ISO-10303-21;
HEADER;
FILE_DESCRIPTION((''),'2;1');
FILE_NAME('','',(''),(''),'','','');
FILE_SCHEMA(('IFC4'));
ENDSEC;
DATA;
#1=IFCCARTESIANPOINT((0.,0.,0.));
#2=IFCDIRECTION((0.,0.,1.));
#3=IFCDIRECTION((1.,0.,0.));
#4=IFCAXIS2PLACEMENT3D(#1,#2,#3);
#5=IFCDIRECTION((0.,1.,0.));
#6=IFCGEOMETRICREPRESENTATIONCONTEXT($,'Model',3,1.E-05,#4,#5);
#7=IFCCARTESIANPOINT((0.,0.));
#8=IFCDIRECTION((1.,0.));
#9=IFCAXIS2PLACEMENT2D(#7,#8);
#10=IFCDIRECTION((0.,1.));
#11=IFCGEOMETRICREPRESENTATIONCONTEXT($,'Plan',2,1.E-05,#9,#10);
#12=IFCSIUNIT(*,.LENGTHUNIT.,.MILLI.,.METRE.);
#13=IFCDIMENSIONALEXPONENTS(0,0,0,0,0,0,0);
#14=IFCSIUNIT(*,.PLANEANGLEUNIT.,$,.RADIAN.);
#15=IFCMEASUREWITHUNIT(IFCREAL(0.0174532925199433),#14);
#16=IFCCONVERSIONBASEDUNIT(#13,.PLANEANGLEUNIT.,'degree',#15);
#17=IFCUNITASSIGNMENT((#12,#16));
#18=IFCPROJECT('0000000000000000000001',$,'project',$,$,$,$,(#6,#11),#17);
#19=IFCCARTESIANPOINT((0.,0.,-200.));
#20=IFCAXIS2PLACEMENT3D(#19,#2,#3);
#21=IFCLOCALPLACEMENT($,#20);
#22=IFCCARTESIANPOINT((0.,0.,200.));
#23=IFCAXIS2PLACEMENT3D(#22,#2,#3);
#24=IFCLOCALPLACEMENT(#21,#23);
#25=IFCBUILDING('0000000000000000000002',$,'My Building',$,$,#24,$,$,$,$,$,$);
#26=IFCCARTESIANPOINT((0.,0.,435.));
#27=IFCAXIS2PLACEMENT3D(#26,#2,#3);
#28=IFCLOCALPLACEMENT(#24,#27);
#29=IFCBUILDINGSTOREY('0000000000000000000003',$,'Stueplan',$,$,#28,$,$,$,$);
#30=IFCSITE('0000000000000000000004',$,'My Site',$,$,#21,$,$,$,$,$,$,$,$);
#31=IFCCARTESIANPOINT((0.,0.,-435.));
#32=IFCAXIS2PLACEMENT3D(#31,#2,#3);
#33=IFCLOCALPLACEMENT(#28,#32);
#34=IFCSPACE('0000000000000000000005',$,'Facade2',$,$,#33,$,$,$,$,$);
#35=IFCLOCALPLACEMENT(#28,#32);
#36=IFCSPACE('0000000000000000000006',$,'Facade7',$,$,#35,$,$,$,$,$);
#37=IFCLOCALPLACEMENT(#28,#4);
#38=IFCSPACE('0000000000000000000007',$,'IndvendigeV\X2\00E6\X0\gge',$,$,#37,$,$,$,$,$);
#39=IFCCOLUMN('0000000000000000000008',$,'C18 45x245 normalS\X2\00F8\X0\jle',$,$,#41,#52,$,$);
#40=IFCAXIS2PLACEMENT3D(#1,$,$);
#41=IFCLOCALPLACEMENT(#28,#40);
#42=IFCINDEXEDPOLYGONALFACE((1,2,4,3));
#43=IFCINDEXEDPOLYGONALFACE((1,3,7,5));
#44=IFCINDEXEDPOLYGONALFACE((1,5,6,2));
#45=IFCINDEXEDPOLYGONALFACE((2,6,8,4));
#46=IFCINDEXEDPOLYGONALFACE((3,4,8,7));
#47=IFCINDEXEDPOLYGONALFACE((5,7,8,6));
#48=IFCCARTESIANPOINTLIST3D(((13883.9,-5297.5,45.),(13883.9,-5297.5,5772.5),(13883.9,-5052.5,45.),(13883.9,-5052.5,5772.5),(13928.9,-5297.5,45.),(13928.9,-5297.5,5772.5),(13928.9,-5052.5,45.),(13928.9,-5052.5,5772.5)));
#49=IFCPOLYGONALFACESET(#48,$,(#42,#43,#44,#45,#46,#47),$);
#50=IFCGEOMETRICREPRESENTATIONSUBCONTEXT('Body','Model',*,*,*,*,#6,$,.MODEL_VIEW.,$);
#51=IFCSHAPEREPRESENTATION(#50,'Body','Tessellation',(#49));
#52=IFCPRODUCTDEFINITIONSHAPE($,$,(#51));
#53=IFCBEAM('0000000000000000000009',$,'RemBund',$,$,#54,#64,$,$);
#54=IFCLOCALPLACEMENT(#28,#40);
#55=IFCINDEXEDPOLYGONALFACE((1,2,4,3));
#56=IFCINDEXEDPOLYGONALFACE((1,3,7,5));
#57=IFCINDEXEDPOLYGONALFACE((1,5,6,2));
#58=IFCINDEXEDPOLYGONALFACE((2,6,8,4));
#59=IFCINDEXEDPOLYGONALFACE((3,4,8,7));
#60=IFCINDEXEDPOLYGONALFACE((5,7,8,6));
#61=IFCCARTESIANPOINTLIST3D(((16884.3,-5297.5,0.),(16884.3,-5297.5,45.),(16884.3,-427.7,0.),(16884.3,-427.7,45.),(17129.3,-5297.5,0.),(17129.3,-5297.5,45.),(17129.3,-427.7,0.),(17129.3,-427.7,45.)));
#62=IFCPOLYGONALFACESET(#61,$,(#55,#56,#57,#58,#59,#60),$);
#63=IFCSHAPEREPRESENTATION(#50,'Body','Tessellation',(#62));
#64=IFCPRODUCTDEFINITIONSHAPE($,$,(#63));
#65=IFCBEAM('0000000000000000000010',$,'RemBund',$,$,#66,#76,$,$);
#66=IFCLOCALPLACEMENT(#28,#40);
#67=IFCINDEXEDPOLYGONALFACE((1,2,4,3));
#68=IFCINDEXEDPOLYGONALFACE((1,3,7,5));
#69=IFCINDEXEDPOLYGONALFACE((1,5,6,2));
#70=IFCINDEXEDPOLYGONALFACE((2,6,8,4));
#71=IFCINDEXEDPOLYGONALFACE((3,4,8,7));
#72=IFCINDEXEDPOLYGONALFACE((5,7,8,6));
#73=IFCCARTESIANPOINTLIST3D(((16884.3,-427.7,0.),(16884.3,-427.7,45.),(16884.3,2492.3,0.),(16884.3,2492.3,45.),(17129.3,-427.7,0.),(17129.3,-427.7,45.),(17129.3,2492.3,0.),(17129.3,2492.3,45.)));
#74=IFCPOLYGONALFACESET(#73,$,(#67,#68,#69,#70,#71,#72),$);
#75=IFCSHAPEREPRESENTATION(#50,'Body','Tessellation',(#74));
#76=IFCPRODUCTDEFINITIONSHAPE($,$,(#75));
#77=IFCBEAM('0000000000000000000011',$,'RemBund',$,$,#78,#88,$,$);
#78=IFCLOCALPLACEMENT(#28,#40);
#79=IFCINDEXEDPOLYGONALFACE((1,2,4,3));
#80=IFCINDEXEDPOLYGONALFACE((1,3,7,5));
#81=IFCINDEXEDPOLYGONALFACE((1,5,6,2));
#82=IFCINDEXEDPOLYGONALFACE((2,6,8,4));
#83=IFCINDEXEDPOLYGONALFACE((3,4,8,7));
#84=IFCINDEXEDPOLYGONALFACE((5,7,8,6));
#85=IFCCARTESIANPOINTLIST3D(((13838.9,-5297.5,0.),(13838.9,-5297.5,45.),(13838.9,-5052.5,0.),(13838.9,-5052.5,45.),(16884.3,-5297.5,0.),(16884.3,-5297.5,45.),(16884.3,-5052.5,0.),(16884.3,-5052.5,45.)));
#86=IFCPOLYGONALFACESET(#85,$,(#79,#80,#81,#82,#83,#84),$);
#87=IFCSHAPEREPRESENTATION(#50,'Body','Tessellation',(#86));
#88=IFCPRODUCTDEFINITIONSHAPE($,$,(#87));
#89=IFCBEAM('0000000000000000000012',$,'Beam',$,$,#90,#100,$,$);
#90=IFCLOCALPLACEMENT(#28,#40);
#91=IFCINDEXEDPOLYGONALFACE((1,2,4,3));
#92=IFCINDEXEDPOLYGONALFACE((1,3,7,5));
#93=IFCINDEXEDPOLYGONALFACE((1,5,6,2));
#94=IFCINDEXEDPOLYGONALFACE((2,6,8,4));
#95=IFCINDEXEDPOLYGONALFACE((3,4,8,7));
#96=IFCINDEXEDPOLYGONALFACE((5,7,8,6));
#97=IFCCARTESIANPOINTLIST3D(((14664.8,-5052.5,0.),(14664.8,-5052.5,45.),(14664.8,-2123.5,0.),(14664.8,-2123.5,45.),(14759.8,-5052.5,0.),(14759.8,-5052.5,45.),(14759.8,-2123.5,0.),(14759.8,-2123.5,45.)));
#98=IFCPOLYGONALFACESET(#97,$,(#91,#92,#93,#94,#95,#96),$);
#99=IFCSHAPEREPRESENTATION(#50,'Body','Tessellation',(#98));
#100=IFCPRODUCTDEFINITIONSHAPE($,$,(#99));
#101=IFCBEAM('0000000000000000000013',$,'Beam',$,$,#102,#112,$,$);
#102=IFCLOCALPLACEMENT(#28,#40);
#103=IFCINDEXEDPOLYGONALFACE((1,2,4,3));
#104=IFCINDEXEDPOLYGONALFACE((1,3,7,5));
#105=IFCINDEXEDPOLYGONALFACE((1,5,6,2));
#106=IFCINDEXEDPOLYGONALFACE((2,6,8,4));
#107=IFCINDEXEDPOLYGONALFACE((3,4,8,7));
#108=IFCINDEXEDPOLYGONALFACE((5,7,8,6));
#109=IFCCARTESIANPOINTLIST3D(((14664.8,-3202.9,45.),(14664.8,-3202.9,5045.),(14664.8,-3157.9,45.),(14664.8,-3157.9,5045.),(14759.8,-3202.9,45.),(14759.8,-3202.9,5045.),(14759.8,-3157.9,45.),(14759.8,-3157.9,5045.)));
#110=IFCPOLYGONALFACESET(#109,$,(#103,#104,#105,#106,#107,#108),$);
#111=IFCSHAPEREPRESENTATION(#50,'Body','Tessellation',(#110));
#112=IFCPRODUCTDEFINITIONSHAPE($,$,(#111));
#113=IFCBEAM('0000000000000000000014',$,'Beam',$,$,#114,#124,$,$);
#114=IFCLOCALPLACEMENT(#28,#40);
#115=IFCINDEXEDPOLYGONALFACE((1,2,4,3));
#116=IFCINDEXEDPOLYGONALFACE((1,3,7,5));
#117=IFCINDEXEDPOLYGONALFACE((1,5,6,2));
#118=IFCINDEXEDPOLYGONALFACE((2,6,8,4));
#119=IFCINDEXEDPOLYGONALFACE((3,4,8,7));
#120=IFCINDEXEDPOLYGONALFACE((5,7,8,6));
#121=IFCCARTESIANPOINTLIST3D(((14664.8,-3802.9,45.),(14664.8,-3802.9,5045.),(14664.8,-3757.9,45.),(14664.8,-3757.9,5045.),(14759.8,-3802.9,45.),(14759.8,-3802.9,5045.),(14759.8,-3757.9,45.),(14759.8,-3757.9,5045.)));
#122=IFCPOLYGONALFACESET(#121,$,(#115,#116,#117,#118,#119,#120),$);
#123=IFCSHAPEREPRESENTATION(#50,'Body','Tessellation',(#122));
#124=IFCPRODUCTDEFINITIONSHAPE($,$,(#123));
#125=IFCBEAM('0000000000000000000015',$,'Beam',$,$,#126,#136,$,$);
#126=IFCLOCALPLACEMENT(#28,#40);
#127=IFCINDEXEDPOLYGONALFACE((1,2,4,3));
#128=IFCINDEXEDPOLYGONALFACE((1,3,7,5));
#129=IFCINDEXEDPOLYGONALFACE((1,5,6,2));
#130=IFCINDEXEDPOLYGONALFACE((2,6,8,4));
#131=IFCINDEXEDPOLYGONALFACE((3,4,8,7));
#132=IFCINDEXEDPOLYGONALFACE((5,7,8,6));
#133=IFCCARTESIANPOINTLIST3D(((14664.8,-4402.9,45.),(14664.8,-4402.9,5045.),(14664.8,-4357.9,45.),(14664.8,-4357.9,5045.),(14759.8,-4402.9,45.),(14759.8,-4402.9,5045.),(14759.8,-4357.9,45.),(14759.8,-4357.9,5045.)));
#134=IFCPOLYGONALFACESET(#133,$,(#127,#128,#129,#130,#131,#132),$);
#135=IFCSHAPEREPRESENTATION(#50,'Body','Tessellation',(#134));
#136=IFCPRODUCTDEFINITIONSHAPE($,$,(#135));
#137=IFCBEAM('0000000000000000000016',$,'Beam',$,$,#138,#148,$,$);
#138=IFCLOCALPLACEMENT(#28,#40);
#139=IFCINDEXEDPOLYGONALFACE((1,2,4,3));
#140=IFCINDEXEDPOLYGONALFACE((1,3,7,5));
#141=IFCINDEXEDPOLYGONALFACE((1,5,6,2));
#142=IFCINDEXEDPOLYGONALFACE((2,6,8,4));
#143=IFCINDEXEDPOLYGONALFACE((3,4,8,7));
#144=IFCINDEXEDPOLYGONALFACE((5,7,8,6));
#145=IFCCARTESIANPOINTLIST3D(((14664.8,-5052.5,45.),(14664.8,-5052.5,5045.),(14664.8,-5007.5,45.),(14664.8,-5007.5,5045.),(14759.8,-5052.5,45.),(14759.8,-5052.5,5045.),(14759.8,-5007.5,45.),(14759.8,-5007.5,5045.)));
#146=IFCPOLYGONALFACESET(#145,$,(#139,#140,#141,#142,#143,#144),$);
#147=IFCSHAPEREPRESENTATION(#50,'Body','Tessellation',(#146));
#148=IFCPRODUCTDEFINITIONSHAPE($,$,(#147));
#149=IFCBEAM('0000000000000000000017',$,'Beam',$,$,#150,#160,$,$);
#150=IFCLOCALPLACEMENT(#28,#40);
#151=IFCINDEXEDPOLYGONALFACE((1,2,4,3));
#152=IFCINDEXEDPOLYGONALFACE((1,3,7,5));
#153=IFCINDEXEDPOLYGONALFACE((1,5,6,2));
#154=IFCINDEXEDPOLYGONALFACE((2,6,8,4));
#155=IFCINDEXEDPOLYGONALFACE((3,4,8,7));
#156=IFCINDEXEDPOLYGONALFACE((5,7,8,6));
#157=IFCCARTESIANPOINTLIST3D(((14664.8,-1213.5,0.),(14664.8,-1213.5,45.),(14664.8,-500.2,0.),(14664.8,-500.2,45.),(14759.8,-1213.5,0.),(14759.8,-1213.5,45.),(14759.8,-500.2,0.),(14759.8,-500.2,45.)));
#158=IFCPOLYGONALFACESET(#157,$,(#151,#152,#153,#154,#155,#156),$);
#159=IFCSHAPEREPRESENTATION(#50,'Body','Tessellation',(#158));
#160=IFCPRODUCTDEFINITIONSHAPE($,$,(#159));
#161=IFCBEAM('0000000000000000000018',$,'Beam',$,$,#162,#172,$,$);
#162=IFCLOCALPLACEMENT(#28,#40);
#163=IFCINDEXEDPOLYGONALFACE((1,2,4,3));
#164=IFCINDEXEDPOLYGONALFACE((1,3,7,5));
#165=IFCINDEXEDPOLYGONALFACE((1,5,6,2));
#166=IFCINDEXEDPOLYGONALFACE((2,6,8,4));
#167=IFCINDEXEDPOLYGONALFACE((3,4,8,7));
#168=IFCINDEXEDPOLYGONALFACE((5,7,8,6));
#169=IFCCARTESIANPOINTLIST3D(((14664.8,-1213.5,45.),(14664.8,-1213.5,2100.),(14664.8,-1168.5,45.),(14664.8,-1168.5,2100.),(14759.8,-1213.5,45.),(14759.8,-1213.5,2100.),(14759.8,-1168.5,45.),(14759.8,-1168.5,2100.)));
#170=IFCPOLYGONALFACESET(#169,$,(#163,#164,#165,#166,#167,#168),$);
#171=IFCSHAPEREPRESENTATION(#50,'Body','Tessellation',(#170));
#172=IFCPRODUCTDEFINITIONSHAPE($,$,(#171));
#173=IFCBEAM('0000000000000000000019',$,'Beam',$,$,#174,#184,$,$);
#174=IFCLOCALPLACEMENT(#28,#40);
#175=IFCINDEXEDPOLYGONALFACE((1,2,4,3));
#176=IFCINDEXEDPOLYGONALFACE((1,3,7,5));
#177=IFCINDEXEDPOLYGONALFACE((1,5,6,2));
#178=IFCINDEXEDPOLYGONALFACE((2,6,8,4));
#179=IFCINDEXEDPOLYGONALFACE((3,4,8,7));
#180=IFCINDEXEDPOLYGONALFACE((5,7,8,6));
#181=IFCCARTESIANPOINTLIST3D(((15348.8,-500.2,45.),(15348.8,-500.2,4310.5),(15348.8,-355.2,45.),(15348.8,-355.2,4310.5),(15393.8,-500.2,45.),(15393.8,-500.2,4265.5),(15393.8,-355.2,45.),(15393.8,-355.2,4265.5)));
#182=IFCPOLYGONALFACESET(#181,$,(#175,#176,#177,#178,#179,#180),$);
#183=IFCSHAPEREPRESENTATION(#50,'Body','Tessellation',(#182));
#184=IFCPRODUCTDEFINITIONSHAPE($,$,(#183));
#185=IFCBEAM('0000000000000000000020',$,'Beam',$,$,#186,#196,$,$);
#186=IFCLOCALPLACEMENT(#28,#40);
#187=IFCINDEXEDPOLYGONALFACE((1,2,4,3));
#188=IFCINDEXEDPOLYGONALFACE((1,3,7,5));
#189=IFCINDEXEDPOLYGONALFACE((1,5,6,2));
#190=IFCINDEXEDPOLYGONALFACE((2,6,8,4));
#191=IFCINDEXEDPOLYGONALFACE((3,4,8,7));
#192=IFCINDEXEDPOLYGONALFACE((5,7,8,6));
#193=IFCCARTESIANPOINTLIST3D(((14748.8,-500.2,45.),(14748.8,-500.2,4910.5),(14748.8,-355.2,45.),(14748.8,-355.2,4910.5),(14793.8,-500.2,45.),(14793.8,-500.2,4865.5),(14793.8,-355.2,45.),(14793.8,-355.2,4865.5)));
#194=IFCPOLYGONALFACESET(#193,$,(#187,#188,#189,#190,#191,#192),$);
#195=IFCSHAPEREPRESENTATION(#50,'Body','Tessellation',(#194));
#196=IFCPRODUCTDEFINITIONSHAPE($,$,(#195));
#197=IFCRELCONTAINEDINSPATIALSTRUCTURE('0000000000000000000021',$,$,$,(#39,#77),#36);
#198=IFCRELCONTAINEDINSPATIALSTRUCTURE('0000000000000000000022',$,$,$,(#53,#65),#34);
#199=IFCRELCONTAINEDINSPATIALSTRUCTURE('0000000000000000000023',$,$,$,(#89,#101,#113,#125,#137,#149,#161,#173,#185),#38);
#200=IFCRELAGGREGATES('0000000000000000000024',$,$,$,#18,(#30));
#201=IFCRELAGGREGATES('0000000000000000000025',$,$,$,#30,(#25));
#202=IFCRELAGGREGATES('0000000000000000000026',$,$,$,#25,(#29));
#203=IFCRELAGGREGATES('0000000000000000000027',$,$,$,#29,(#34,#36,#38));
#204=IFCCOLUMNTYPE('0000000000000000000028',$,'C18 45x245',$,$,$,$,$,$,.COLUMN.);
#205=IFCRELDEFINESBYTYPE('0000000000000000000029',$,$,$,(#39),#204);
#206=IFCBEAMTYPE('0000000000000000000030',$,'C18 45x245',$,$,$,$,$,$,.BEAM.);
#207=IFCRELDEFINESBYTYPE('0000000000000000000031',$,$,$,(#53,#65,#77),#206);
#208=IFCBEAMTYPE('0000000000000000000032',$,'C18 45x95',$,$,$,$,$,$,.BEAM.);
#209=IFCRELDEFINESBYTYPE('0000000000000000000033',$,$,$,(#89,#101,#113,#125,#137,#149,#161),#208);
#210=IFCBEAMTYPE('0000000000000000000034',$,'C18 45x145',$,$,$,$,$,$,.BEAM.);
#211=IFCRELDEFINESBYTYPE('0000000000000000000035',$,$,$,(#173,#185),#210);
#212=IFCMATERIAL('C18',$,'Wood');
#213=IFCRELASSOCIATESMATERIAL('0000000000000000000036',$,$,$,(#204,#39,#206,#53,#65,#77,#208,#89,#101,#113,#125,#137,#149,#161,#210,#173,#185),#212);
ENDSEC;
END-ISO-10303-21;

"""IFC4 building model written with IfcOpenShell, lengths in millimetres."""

from ifc_helpers import new_model, entity, si_unit, converted_unit, direction, frame, origin_with_axes, origin_2d_with_axis, place, context, subcontext, project, spatial, rectangle, extrude, clip, halfspace, material, material_profile, profile_set, profile_usage, type_object, element, save


model = new_model("IFC4")

# Units and contexts
model_context = context("Model", 3, precision=1e-05, world=origin_with_axes(), true_north=direction((0.0, 1.0, 0.0)))
plan_context = context("Plan", 2, precision=1e-05, world=origin_2d_with_axis(), true_north=direction((0.0, 1.0)))
body_context_1 = subcontext(model_context, "Body", "Model", "MODEL_VIEW")
ifc_project = project(units=[si_unit("LENGTHUNIT", "METRE", prefix="MILLI"), converted_unit("PLANEANGLEUNIT", "degree", entity("IfcReal", 0.0174532925199433), si_unit("PLANEANGLEUNIT", "RADIAN"), dimensions=[0, 0, 0, 0, 0, 0, 0])], contexts=[model_context, plan_context])

# Site, building, storey, space
site_placement = place(None, frame((0.0, 0.0, -200.0), z_axis=(0.0, 0.0, 1.0), x_axis=(1.0, 0.0, 0.0)))
site = spatial("IfcSite", under=ifc_project, at=site_placement, Name="My Site")
building_placement = place(site_placement, frame((0.0, 0.0, 200.0), z_axis=(0.0, 0.0, 1.0), x_axis=(1.0, 0.0, 0.0)))
building = spatial("IfcBuilding", under=site, at=building_placement, Name="My Building")
storey_placement = place(building_placement, frame((0.0, 0.0, 435.0), z_axis=(0.0, 0.0, 1.0), x_axis=(1.0, 0.0, 0.0)))
storey = spatial("IfcBuildingStorey", under=building, at=storey_placement, Name="Stueplan")
space_1_placement = place(storey_placement, frame((0.0, 0.0, -435.0), z_axis=(0.0, 0.0, 1.0), x_axis=(1.0, 0.0, 0.0)))
space_1 = spatial("IfcSpace", under=storey, at=space_1_placement, Name="Facade2")

# Shared definitions
ifc_material = material(Name="C18", Category="Wood")
ifc_material_profile_1 = material_profile(ifc_material, rectangle(XDim=45.0, YDim=245.0))
ifc_profile_set_1 = profile_set([ifc_material_profile_1], Name="woodStructural")
column_type = type_object("IfcColumnType", Name="C18 45x245", PredefinedType="COLUMN", material=ifc_profile_set_1)

# Shared definitions
space_2_placement = place(storey_placement, frame((0.0, 0.0, -435.0), z_axis=(0.0, 0.0, 1.0), x_axis=(1.0, 0.0, 0.0)))
space_2 = spatial("IfcSpace", under=storey, at=space_2_placement, Name="Facade7")

# Column
ifc_profile_usage_1 = profile_usage(ifc_profile_set_1, cardinal=9)
column_1_placement = place(space_2_placement, frame((13928.9, -5297.5, 480.0), z_axis=(0.0, 0.0, 1.0), x_axis=(-1.0, 0.0, 0.0)))
element("IfcColumn", 1, at=column_1_placement, inside=space_2, type_object=column_type, material=ifc_profile_usage_1, Name="C18 45x245 normalSøjle", context=body_context_1, shape_type="SweptSolid", body=[
    extrude(rectangle(XDim=45.0, YDim=245.0), frame((22.5, -122.5, 0.0), z_axis=(0.0, 0.0, 1.0), x_axis=(1.0, 0.0, 0.0)), (0.0, 0.0, 1.0), 5727.5),
])

# Beams
ifc_material_profile_2 = material_profile(ifc_material, rectangle(XDim=45.0, YDim=245.0), Name="concrete")
ifc_profile_set_2 = profile_set([ifc_material_profile_2], Name="woodStructural")
ifc_profile_usage_2 = profile_usage(ifc_profile_set_2)
beam_type_1 = type_object("IfcBeamType", Name="C18 45x245", PredefinedType="BEAM", material=ifc_profile_set_2)
beam_1_placement = place(space_1_placement, frame((17006.8, -5297.5, 457.5), z_axis=(0.0, 1.0, 0.0), x_axis=(0.0, 0.0, 1.0)))
element("IfcBeam", 2, at=beam_1_placement, inside=space_1, type_object=beam_type_1, material=ifc_profile_usage_2, Name="RemBund", context=body_context_1, shape_type="SweptSolid", body=[
    extrude(rectangle(XDim=45.0, YDim=245.0), origin_with_axes(), (0.0, 0.0, 1.0), 4869.8),
])
ifc_profile_usage_3 = profile_usage(ifc_profile_set_2)
beam_2_placement = place(space_1_placement, frame((17006.8, -427.7, 457.5), z_axis=(0.0, 1.0, 0.0), x_axis=(0.0, 0.0, 1.0)))
element("IfcBeam", 3, at=beam_2_placement, inside=space_1, type_object=beam_type_1, material=ifc_profile_usage_3, Name="RemBund", context=body_context_1, shape_type="SweptSolid", body=[
    extrude(rectangle(XDim=45.0, YDim=245.0), origin_with_axes(), (0.0, 0.0, 1.0), 2920.0),
])
ifc_profile_usage_4 = profile_usage(ifc_profile_set_2)
beam_3_placement = place(space_2_placement, frame((13838.9, -5175.0, 457.5), z_axis=(1.0, 0.0, 0.0), x_axis=(0.0, 0.0, 1.0)))
element("IfcBeam", 4, at=beam_3_placement, inside=space_2, type_object=beam_type_1, material=ifc_profile_usage_4, Name="RemBund", context=body_context_1, shape_type="SweptSolid", body=[
    extrude(rectangle(XDim=45.0, YDim=245.0), origin_with_axes(), (0.0, 0.0, 1.0), 3045.3),
])

# Shared definitions
space_3_placement = place(storey_placement, frame((0.0, 0.0, 0.0), z_axis=(0.0, 0.0, 1.0), x_axis=(1.0, 0.0, 0.0)))
space_3 = spatial("IfcSpace", under=storey, at=space_3_placement, Name="IndvendigeVægge")

# Beams
ifc_material_profile_3 = material_profile(ifc_material, rectangle(XDim=45.0, YDim=95.0))
ifc_profile_set_3 = profile_set([ifc_material_profile_3], Name="woodStructural")
ifc_profile_usage_5 = profile_usage(ifc_profile_set_3, cardinal=5)
beam_type_2 = type_object("IfcBeamType", Name="C18 45x95", PredefinedType="BEAM", material=ifc_profile_set_3)
beam_4_placement = place(space_3_placement, frame((14712.3, -5052.5, 22.5), z_axis=(0.0, 1.0, 0.0), x_axis=(0.0, 0.0, 1.0)))
element("IfcBeam", 5, at=beam_4_placement, inside=space_3, type_object=beam_type_2, material=ifc_profile_usage_5, Name="Beam", context=body_context_1, shape_type="SweptSolid", body=[
    extrude(rectangle(XDim=45.0, YDim=95.0), origin_with_axes(), (0.0, 0.0, 1.0), 2929.0),
])
ifc_profile_usage_6 = profile_usage(ifc_profile_set_3)
beam_5_placement = place(space_3_placement, frame((14712.3, -3180.4, 45.0), z_axis=(0.0, 0.0, 1.0), x_axis=(0.0, 1.0, 0.0)))
element("IfcBeam", 6, at=beam_5_placement, inside=space_3, type_object=beam_type_2, material=ifc_profile_usage_6, Name="Beam", context=body_context_1, shape_type="SweptSolid", body=[
    extrude(rectangle(XDim=45.0, YDim=95.0), origin_with_axes(), (0.0, 0.0, 1.0), 5000.0),
])
ifc_profile_usage_7 = profile_usage(ifc_profile_set_3)
beam_6_placement = place(space_3_placement, frame((14712.3, -3780.4, 45.0), z_axis=(0.0, 0.0, 1.0), x_axis=(0.0, 1.0, 0.0)))
element("IfcBeam", 7, at=beam_6_placement, inside=space_3, type_object=beam_type_2, material=ifc_profile_usage_7, Name="Beam", context=body_context_1, shape_type="SweptSolid", body=[
    extrude(rectangle(XDim=45.0, YDim=95.0), origin_with_axes(), (0.0, 0.0, 1.0), 5000.0),
])
ifc_profile_usage_8 = profile_usage(ifc_profile_set_3)
beam_7_placement = place(space_3_placement, frame((14712.3, -4380.4, 45.0), z_axis=(0.0, 0.0, 1.0), x_axis=(0.0, 1.0, 0.0)))
element("IfcBeam", 8, at=beam_7_placement, inside=space_3, type_object=beam_type_2, material=ifc_profile_usage_8, Name="Beam", context=body_context_1, shape_type="SweptSolid", body=[
    extrude(rectangle(XDim=45.0, YDim=95.0), origin_with_axes(), (0.0, 0.0, 1.0), 5000.0),
])
ifc_profile_usage_9 = profile_usage(ifc_profile_set_3)
beam_8_placement = place(space_3_placement, frame((14712.3, -5030.0, 45.0), z_axis=(0.0, 0.0, 1.0), x_axis=(0.0, 1.0, 0.0)))
element("IfcBeam", 9, at=beam_8_placement, inside=space_3, type_object=beam_type_2, material=ifc_profile_usage_9, Name="Beam", context=body_context_1, shape_type="SweptSolid", body=[
    extrude(rectangle(XDim=45.0, YDim=95.0), origin_with_axes(), (0.0, 0.0, 1.0), 5000.0),
])
ifc_profile_usage_10 = profile_usage(ifc_profile_set_3, cardinal=5)
beam_9_placement = place(space_3_placement, frame((14712.3, -1213.5, 22.5), z_axis=(0.0, 1.0, 0.0), x_axis=(0.0, 0.0, 1.0)))
element("IfcBeam", 10, at=beam_9_placement, inside=space_3, type_object=beam_type_2, material=ifc_profile_usage_10, Name="Beam", context=body_context_1, shape_type="SweptSolid", body=[
    extrude(rectangle(XDim=45.0, YDim=95.0), origin_with_axes(), (0.0, 0.0, 1.0), 713.3),
])
ifc_profile_usage_11 = profile_usage(ifc_profile_set_3)
beam_10_placement = place(space_3_placement, frame((14712.3, -1191.0, 45.0), z_axis=(0.0, 0.0, 1.0), x_axis=(0.0, 1.0, 0.0)))
element("IfcBeam", 11, at=beam_10_placement, inside=space_3, type_object=beam_type_2, material=ifc_profile_usage_11, Name="Beam", context=body_context_1, shape_type="SweptSolid", body=[
    extrude(rectangle(XDim=45.0, YDim=95.0), origin_with_axes(), (0.0, 0.0, 1.0), 2055.0),
])
ifc_material_profile_4 = material_profile(ifc_material, rectangle(XDim=45.0, YDim=145.0))
ifc_profile_set_4 = profile_set([ifc_material_profile_4], Name="woodStructural")
ifc_profile_usage_12 = profile_usage(ifc_profile_set_4)
beam_type_3 = type_object("IfcBeamType", Name="C18 45x145", PredefinedType="BEAM", material=ifc_profile_set_4)
beam_11_placement = place(space_3_placement, frame((15371.3, -427.7, 45.0), z_axis=(0.0, 0.0, 1.0), x_axis=(-1.0, 0.0, 0.0)))
element("IfcBeam", 12, at=beam_11_placement, inside=space_3, type_object=beam_type_3, material=ifc_profile_usage_12, Name="Beam", context=body_context_1, shape_type="Clipping", body=[
    clip(extrude(rectangle(XDim=45.0, YDim=145.0), origin_with_axes(), (0.0, 0.0, 1.0), 4388.0), halfspace(frame((1555.8, 0.0, 5798.8), z_axis=(-0.707107, 0.0, 0.707107), x_axis=(0.0, 1.0, 0.0)), False)),
])
ifc_profile_usage_13 = profile_usage(ifc_profile_set_4)
beam_12_placement = place(space_3_placement, frame((14771.3, -427.7, 45.0), z_axis=(0.0, 0.0, 1.0), x_axis=(-1.0, 0.0, 0.0)))
element("IfcBeam", 13, at=beam_12_placement, inside=space_3, type_object=beam_type_3, material=ifc_profile_usage_13, Name="Beam", context=body_context_1, shape_type="Clipping", body=[
    clip(extrude(rectangle(XDim=45.0, YDim=145.0), origin_with_axes(), (0.0, 0.0, 1.0), 4988.0), halfspace(frame((955.8, 0.0, 5798.8), z_axis=(-0.707107, 0.0, 0.707107), x_axis=(0.0, 1.0, 0.0)), False)),
])

save(model, "model.ifc")
